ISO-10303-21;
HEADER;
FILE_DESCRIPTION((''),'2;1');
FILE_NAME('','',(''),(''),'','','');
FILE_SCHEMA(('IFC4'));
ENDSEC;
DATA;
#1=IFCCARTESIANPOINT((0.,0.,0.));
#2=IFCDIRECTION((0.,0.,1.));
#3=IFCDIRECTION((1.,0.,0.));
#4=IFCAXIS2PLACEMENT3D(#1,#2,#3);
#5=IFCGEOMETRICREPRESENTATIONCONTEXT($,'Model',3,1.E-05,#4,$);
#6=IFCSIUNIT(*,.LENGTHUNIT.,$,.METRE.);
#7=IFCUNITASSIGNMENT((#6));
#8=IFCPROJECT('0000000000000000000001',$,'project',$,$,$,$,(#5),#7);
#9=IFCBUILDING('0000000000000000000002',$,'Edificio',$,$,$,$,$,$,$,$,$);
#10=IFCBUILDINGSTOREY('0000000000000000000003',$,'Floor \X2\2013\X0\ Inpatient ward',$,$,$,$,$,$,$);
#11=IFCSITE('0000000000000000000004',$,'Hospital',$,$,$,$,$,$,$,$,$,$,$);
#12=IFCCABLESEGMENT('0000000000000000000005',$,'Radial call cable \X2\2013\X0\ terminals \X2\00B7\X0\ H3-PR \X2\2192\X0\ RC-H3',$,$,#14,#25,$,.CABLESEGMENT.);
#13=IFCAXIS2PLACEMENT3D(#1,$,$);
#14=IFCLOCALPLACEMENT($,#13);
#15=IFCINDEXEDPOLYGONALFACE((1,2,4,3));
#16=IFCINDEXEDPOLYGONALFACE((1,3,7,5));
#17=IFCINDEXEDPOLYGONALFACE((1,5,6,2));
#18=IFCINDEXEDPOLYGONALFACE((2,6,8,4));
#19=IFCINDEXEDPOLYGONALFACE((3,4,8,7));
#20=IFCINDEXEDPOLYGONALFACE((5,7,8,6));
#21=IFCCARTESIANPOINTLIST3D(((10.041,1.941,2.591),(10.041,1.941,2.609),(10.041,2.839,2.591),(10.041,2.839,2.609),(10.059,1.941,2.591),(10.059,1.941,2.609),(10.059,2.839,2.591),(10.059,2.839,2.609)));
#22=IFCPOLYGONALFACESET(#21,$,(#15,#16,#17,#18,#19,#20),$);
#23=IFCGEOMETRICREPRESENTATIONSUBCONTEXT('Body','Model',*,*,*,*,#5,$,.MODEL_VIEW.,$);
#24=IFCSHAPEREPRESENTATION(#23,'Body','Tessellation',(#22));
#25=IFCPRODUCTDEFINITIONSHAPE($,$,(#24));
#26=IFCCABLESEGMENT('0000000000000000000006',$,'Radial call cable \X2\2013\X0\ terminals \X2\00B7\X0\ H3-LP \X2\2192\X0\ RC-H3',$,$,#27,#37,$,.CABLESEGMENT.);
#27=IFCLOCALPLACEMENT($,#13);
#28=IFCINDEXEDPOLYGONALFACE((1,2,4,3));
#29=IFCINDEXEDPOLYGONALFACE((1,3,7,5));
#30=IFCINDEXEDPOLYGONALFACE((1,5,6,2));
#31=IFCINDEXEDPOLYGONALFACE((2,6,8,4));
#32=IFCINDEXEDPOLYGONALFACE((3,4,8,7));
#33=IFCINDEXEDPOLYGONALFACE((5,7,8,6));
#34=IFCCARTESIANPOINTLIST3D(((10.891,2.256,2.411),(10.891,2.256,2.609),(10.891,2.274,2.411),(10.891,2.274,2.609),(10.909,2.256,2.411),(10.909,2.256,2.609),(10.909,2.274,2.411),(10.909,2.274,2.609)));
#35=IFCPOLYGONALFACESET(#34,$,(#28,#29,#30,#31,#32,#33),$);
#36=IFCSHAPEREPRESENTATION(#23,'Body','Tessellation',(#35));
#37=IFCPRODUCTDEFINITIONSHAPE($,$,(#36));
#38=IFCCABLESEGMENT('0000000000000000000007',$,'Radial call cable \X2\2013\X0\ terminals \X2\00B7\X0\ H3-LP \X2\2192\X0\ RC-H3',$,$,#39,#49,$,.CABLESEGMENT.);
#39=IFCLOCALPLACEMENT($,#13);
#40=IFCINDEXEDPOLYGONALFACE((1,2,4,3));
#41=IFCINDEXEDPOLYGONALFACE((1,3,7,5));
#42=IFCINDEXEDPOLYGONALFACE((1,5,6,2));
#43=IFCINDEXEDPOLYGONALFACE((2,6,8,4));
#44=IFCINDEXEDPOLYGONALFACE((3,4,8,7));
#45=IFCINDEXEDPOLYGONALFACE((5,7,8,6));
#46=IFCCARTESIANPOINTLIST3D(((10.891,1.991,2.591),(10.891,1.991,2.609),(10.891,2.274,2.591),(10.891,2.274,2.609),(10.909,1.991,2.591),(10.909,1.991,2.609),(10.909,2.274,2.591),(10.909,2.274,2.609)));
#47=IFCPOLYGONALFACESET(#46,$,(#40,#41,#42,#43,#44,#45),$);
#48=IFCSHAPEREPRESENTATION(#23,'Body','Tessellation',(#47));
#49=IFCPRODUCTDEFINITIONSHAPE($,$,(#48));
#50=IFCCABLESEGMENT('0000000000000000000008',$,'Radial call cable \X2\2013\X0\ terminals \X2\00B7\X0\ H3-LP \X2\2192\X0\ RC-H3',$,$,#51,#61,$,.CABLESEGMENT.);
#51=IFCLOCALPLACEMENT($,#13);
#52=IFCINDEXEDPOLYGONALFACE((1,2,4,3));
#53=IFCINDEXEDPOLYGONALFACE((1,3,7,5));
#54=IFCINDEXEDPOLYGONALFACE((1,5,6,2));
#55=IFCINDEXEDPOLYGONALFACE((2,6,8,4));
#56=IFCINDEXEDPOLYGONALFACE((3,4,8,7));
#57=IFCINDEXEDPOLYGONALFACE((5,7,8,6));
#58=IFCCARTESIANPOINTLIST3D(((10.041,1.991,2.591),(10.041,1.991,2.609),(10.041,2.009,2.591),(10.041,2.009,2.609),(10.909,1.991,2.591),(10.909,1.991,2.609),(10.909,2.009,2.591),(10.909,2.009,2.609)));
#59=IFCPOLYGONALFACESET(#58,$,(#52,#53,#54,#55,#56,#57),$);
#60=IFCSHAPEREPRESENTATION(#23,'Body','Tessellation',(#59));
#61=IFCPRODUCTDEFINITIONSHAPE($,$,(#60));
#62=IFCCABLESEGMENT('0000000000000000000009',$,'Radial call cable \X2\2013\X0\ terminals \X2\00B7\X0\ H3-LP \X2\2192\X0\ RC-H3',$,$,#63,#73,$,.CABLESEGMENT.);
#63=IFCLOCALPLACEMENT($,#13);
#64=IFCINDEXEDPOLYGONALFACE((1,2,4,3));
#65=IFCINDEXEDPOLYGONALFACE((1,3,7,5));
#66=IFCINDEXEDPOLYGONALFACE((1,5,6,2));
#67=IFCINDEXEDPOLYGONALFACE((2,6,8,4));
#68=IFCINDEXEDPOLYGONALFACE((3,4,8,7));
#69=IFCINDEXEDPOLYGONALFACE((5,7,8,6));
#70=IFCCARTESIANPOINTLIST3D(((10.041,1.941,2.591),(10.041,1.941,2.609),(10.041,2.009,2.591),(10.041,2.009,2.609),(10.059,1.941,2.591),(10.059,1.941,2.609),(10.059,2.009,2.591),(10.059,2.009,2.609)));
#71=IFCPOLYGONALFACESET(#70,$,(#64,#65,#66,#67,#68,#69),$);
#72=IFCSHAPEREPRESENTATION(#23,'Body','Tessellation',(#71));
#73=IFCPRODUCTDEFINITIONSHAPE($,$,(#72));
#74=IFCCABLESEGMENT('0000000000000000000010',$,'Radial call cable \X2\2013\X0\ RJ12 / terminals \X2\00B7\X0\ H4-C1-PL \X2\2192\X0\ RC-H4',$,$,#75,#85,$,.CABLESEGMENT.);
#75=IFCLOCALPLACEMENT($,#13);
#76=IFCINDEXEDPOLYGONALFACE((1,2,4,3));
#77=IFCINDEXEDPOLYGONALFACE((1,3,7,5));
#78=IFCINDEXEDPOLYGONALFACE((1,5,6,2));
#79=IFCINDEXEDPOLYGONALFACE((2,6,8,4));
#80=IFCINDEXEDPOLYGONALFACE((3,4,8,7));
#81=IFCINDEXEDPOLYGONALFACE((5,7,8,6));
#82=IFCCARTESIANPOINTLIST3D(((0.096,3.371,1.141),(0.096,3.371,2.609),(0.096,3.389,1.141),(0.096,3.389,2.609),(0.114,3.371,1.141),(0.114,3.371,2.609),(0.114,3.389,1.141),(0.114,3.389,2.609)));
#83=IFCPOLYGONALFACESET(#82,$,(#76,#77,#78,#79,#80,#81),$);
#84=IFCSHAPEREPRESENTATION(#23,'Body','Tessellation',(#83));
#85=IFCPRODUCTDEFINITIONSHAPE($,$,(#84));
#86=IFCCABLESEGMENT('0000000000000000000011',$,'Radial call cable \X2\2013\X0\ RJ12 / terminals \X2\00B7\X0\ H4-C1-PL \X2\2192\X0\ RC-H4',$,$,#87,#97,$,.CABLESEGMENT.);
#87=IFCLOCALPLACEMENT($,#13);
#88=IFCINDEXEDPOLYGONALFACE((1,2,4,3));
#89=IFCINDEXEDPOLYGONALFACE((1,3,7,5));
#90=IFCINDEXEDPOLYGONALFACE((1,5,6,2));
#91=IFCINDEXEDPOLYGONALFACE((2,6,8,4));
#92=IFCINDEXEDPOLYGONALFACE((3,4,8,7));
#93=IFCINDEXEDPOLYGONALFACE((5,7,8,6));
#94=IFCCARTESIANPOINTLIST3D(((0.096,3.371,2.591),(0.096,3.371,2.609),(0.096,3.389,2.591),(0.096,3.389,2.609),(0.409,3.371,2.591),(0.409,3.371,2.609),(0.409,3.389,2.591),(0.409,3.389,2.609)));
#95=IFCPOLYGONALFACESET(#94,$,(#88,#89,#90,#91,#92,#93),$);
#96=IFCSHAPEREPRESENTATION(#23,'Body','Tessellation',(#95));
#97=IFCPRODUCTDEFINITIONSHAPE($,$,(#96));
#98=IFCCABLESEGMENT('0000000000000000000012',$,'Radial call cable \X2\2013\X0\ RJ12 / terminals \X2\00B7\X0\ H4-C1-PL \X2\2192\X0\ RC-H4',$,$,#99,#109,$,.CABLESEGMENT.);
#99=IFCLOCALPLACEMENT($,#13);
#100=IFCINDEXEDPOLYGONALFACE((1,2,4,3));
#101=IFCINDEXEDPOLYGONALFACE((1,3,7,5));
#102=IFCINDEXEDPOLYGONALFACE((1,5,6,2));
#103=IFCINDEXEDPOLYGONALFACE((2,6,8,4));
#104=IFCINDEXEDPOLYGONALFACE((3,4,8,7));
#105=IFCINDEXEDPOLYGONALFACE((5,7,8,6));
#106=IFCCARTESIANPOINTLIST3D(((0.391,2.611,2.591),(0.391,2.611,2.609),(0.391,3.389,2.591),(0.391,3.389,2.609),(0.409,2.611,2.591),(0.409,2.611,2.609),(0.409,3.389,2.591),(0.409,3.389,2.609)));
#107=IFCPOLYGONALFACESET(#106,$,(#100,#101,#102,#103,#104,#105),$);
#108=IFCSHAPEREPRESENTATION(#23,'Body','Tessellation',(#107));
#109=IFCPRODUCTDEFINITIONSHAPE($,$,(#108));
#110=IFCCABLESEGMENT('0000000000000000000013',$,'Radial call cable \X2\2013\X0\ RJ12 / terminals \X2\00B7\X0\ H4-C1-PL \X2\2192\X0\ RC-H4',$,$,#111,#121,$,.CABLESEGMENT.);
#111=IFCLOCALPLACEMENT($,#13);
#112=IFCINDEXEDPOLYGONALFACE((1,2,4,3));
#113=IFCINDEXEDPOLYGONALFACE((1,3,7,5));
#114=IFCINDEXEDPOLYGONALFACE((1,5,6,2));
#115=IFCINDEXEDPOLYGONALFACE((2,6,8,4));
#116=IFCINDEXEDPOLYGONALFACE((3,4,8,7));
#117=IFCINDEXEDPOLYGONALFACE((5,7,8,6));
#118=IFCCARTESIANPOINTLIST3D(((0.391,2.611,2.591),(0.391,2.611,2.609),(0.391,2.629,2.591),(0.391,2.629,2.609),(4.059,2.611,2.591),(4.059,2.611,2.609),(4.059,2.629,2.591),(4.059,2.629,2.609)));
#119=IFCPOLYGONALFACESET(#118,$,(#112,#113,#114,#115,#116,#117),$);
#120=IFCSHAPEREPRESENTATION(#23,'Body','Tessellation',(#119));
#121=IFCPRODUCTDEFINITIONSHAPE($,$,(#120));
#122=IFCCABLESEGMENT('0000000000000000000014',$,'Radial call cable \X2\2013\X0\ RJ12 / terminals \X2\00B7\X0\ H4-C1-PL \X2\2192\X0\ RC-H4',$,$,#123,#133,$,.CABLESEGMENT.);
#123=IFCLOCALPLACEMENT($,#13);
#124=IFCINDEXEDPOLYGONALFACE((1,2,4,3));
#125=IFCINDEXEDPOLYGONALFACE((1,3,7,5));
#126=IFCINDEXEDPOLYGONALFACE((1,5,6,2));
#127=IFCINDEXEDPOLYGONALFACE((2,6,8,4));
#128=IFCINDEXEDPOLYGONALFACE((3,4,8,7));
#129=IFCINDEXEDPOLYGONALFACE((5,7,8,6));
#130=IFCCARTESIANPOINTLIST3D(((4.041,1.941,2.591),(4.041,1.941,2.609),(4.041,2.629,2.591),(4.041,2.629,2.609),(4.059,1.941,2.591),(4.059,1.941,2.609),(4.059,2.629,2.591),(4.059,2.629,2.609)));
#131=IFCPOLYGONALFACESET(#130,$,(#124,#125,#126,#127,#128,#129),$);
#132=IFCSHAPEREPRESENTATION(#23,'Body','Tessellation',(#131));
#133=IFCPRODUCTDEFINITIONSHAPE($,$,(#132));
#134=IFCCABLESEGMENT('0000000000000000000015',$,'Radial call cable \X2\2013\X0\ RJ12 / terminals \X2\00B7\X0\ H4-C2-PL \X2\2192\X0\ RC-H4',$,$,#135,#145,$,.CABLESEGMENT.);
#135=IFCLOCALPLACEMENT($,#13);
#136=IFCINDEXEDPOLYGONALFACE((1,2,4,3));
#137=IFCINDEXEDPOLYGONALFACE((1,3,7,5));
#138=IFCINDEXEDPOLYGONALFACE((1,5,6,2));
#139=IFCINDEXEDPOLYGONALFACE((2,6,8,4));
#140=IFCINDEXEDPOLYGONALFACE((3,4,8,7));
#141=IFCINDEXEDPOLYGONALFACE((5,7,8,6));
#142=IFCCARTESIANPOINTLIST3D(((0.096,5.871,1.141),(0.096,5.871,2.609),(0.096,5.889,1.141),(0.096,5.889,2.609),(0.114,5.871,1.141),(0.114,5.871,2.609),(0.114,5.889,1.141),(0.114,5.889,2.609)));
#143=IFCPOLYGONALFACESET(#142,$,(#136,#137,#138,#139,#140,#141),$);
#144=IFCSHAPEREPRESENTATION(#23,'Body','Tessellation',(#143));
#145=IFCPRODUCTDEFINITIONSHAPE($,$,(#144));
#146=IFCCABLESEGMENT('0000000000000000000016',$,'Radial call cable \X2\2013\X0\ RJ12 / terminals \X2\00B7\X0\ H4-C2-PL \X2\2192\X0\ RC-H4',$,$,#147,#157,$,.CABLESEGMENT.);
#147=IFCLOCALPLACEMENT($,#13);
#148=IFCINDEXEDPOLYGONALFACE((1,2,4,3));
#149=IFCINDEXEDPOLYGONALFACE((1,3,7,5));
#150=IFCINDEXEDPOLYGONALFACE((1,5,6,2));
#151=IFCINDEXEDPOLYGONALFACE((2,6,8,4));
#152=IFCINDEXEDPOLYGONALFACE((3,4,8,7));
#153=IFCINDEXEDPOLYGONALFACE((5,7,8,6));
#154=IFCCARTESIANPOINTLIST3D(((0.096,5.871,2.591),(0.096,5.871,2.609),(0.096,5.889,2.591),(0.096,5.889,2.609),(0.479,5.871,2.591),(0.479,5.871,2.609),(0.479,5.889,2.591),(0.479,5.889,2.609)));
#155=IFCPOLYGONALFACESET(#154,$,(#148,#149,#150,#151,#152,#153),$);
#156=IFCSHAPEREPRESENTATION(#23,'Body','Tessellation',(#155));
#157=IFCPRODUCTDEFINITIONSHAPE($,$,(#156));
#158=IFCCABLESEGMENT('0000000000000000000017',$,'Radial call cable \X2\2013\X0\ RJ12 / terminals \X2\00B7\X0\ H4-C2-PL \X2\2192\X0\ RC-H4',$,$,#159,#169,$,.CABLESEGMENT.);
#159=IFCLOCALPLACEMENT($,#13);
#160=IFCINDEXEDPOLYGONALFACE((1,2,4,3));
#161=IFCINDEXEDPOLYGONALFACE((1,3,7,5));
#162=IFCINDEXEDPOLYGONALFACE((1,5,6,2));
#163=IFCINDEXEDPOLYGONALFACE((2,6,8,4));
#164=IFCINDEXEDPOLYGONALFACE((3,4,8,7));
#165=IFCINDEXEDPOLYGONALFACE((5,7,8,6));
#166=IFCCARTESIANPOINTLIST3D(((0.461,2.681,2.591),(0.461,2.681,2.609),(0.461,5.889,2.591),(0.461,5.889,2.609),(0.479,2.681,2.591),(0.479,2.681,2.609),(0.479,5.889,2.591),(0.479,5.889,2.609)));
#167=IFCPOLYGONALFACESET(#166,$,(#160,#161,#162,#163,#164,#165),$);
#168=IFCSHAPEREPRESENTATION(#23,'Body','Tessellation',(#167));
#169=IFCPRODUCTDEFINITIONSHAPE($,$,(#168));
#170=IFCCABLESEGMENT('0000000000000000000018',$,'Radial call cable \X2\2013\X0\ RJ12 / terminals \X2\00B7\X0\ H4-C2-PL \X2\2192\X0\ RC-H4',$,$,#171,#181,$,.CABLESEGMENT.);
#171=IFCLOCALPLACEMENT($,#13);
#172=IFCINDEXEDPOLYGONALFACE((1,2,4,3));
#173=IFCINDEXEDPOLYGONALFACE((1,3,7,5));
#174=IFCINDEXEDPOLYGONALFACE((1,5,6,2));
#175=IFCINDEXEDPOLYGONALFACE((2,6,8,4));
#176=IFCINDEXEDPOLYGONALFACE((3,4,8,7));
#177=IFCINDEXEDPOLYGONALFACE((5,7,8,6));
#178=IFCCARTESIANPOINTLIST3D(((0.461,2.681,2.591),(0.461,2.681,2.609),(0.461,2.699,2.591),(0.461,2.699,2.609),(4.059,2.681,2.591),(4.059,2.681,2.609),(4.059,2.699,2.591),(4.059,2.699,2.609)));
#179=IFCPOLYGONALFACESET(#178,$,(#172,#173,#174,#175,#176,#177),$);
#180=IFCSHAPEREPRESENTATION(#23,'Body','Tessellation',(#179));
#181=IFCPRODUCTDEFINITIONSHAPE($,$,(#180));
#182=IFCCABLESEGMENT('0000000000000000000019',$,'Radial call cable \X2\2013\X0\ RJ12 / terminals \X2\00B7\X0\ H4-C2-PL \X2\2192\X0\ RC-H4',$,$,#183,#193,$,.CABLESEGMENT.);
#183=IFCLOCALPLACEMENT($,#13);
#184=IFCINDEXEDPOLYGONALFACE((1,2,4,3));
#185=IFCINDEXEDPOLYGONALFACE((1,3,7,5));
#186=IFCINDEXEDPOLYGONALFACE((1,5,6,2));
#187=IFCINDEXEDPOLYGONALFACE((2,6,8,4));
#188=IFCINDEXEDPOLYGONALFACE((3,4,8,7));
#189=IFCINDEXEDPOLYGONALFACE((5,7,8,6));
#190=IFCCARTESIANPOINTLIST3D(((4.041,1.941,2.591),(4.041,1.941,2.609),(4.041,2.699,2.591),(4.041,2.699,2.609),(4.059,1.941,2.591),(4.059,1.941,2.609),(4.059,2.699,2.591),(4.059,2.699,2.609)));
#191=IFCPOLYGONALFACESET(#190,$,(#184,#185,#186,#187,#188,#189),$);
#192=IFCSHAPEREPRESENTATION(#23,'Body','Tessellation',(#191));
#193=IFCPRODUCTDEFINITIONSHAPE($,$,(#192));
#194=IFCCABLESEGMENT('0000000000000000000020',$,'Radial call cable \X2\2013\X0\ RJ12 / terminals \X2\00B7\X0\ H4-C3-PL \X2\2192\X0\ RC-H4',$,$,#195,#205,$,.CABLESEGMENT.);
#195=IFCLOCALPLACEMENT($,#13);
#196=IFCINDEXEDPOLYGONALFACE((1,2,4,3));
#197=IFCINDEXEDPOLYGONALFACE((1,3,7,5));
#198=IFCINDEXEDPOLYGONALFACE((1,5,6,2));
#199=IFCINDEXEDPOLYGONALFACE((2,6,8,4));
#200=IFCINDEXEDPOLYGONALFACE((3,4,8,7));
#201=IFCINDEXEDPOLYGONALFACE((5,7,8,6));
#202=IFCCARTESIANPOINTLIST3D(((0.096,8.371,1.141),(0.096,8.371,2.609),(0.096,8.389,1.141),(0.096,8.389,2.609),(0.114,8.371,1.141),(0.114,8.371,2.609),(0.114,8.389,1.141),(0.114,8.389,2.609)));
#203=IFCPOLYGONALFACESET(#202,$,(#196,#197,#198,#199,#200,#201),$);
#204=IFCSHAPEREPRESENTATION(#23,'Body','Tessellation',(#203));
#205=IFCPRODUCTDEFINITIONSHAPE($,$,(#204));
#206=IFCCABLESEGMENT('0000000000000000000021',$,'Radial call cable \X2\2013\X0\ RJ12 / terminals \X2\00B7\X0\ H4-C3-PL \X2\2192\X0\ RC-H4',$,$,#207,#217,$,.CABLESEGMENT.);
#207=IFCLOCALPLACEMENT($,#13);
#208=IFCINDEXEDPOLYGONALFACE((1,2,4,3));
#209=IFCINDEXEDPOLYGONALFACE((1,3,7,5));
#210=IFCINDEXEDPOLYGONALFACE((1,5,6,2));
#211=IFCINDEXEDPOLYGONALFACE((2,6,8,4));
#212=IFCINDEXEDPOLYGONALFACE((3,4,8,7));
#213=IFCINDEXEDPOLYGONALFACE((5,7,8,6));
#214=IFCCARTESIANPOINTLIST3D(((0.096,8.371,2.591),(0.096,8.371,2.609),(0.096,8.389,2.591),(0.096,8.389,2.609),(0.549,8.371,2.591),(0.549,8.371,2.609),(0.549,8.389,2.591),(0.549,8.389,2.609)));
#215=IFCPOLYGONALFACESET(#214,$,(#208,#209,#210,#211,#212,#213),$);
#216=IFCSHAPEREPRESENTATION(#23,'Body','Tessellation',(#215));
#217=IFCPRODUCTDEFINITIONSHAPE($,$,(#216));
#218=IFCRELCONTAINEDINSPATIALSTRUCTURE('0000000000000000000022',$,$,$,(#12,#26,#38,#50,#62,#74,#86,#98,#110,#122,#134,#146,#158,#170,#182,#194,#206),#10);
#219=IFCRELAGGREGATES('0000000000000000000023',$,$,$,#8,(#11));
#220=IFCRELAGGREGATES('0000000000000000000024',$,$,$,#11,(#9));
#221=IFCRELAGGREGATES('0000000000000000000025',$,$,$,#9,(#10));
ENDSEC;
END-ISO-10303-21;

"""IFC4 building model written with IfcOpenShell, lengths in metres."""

from ifc_helpers import new_model, si_unit, frame, origin_with_axes, context, subcontext, project, spatial, line, indexed_curve, outline, extrude, element, save


model = new_model("IFC4")

# Units and contexts
model_context = context("Model", 3, precision=1e-05, world=origin_with_axes())
body_context = subcontext(model_context, "Body", "Model", "MODEL_VIEW")
ifc_project = project(units=[si_unit("LENGTHUNIT", "METRE")], contexts=[model_context])

# Site, building, storey
site = spatial("IfcSite", under=ifc_project, Name="Hospital")
building = spatial("IfcBuilding", under=site, Name="Edificio")
storey = spatial("IfcBuildingStorey", under=building, Name="Floor – Inpatient ward")

# Cable segments
element("IfcCableSegment", 1, inside=storey, Name="Radial call cable – terminals · H3-PR → RC-H3", PredefinedType="CABLESEGMENT", context=body_context, shape_type="SweptSolid", body=[
    extrude(outline(indexed_curve([(0.0, 0.0), (0.018, 0.0), (0.018, 0.898), (0.0, 0.898)], segments=[line(1, 2, 3, 4, 1)])), frame((10.041, 1.941, 2.591), z_axis=(0.0, 0.0, 1.0), x_axis=(1.0, 0.0, 0.0)), (0.0, 0.0, 1.0), 0.018),
])
element("IfcCableSegment", 2, inside=storey, Name="Radial call cable – terminals · H3-LP → RC-H3", PredefinedType="CABLESEGMENT", context=body_context, shape_type="SweptSolid", body=[
    extrude(outline(indexed_curve([(0.0, 0.0), (0.018, 0.0), (0.018, 0.018), (0.0, 0.018)], segments=[line(1, 2, 3, 4, 1)])), frame((10.891, 2.256, 2.411), z_axis=(0.0, 0.0, 1.0), x_axis=(1.0, 0.0, 0.0)), (0.0, 0.0, 1.0), 0.198),
])
element("IfcCableSegment", 3, inside=storey, Name="Radial call cable – terminals · H3-LP → RC-H3", PredefinedType="CABLESEGMENT", context=body_context, shape_type="SweptSolid", body=[
    extrude(outline(indexed_curve([(0.0, 0.0), (0.018, 0.0), (0.018, 0.283), (0.0, 0.283)], segments=[line(1, 2, 3, 4, 1)])), frame((10.891, 1.991, 2.591), z_axis=(0.0, 0.0, 1.0), x_axis=(1.0, 0.0, 0.0)), (0.0, 0.0, 1.0), 0.018),
])
element("IfcCableSegment", 4, inside=storey, Name="Radial call cable – terminals · H3-LP → RC-H3", PredefinedType="CABLESEGMENT", context=body_context, shape_type="SweptSolid", body=[
    extrude(outline(indexed_curve([(0.0, 0.0), (0.868, 0.0), (0.868, 0.018), (0.0, 0.018)], segments=[line(1, 2, 3, 4, 1)])), frame((10.041, 1.991, 2.591), z_axis=(0.0, 0.0, 1.0), x_axis=(1.0, 0.0, 0.0)), (0.0, 0.0, 1.0), 0.018),
])
element("IfcCableSegment", 5, inside=storey, Name="Radial call cable – terminals · H3-LP → RC-H3", PredefinedType="CABLESEGMENT", context=body_context, shape_type="SweptSolid", body=[
    extrude(outline(indexed_curve([(0.0, 0.0), (0.018, 0.0), (0.018, 0.068), (0.0, 0.068)], segments=[line(1, 2, 3, 4, 1)])), frame((10.041, 1.941, 2.591), z_axis=(0.0, 0.0, 1.0), x_axis=(1.0, 0.0, 0.0)), (0.0, 0.0, 1.0), 0.018),
])
element("IfcCableSegment", 6, inside=storey, Name="Radial call cable – RJ12 / terminals · H4-C1-PL → RC-H4", PredefinedType="CABLESEGMENT", context=body_context, shape_type="SweptSolid", body=[
    extrude(outline(indexed_curve([(0.0, 0.0), (0.018, 0.0), (0.018, 0.018), (0.0, 0.018)], segments=[line(1, 2, 3, 4, 1)])), frame((0.096, 3.371, 1.141), z_axis=(0.0, 0.0, 1.0), x_axis=(1.0, 0.0, 0.0)), (0.0, 0.0, 1.0), 1.468),
])
element("IfcCableSegment", 7, inside=storey, Name="Radial call cable – RJ12 / terminals · H4-C1-PL → RC-H4", PredefinedType="CABLESEGMENT", context=body_context, shape_type="SweptSolid", body=[
    extrude(outline(indexed_curve([(0.0, 0.0), (0.313, 0.0), (0.313, 0.018), (0.0, 0.018)], segments=[line(1, 2, 3, 4, 1)])), frame((0.096, 3.371, 2.591), z_axis=(0.0, 0.0, 1.0), x_axis=(1.0, 0.0, 0.0)), (0.0, 0.0, 1.0), 0.018),
])
element("IfcCableSegment", 8, inside=storey, Name="Radial call cable – RJ12 / terminals · H4-C1-PL → RC-H4", PredefinedType="CABLESEGMENT", context=body_context, shape_type="SweptSolid", body=[
    extrude(outline(indexed_curve([(0.0, 0.0), (0.018, 0.0), (0.018, 0.778), (0.0, 0.778)], segments=[line(1, 2, 3, 4, 1)])), frame((0.391, 2.611, 2.591), z_axis=(0.0, 0.0, 1.0), x_axis=(1.0, 0.0, 0.0)), (0.0, 0.0, 1.0), 0.018),
])
element("IfcCableSegment", 9, inside=storey, Name="Radial call cable – RJ12 / terminals · H4-C1-PL → RC-H4", PredefinedType="CABLESEGMENT", context=body_context, shape_type="SweptSolid", body=[
    extrude(outline(indexed_curve([(0.0, 0.0), (3.668, 0.0), (3.668, 0.018), (0.0, 0.018)], segments=[line(1, 2, 3, 4, 1)])), frame((0.391, 2.611, 2.591), z_axis=(0.0, 0.0, 1.0), x_axis=(1.0, 0.0, 0.0)), (0.0, 0.0, 1.0), 0.018),
])
element("IfcCableSegment", 10, inside=storey, Name="Radial call cable – RJ12 / terminals · H4-C1-PL → RC-H4", PredefinedType="CABLESEGMENT", context=body_context, shape_type="SweptSolid", body=[
    extrude(outline(indexed_curve([(0.0, 0.0), (0.018, 0.0), (0.018, 0.688), (0.0, 0.688)], segments=[line(1, 2, 3, 4, 1)])), frame((4.041, 1.941, 2.591), z_axis=(0.0, 0.0, 1.0), x_axis=(1.0, 0.0, 0.0)), (0.0, 0.0, 1.0), 0.018),
])
element("IfcCableSegment", 11, inside=storey, Name="Radial call cable – RJ12 / terminals · H4-C2-PL → RC-H4", PredefinedType="CABLESEGMENT", context=body_context, shape_type="SweptSolid", body=[
    extrude(outline(indexed_curve([(0.0, 0.0), (0.018, 0.0), (0.018, 0.018), (0.0, 0.018)], segments=[line(1, 2, 3, 4, 1)])), frame((0.096, 5.871, 1.141), z_axis=(0.0, 0.0, 1.0), x_axis=(1.0, 0.0, 0.0)), (0.0, 0.0, 1.0), 1.468),
])
element("IfcCableSegment", 12, inside=storey, Name="Radial call cable – RJ12 / terminals · H4-C2-PL → RC-H4", PredefinedType="CABLESEGMENT", context=body_context, shape_type="SweptSolid", body=[
    extrude(outline(indexed_curve([(0.0, 0.0), (0.383, 0.0), (0.383, 0.018), (0.0, 0.018)], segments=[line(1, 2, 3, 4, 1)])), frame((0.096, 5.871, 2.591), z_axis=(0.0, 0.0, 1.0), x_axis=(1.0, 0.0, 0.0)), (0.0, 0.0, 1.0), 0.018),
])
element("IfcCableSegment", 13, inside=storey, Name="Radial call cable – RJ12 / terminals · H4-C2-PL → RC-H4", PredefinedType="CABLESEGMENT", context=body_context, shape_type="SweptSolid", body=[
    extrude(outline(indexed_curve([(0.0, 0.0), (0.018, 0.0), (0.018, 3.208), (0.0, 3.208)], segments=[line(1, 2, 3, 4, 1)])), frame((0.461, 2.681, 2.591), z_axis=(0.0, 0.0, 1.0), x_axis=(1.0, 0.0, 0.0)), (0.0, 0.0, 1.0), 0.018),
])
element("IfcCableSegment", 14, inside=storey, Name="Radial call cable – RJ12 / terminals · H4-C2-PL → RC-H4", PredefinedType="CABLESEGMENT", context=body_context, shape_type="SweptSolid", body=[
    extrude(outline(indexed_curve([(0.0, 0.0), (3.598, 0.0), (3.598, 0.018), (0.0, 0.018)], segments=[line(1, 2, 3, 4, 1)])), frame((0.461, 2.681, 2.591), z_axis=(0.0, 0.0, 1.0), x_axis=(1.0, 0.0, 0.0)), (0.0, 0.0, 1.0), 0.018),
])
element("IfcCableSegment", 15, inside=storey, Name="Radial call cable – RJ12 / terminals · H4-C2-PL → RC-H4", PredefinedType="CABLESEGMENT", context=body_context, shape_type="SweptSolid", body=[
    extrude(outline(indexed_curve([(0.0, 0.0), (0.018, 0.0), (0.018, 0.758), (0.0, 0.758)], segments=[line(1, 2, 3, 4, 1)])), frame((4.041, 1.941, 2.591), z_axis=(0.0, 0.0, 1.0), x_axis=(1.0, 0.0, 0.0)), (0.0, 0.0, 1.0), 0.018),
])
element("IfcCableSegment", 16, inside=storey, Name="Radial call cable – RJ12 / terminals · H4-C3-PL → RC-H4", PredefinedType="CABLESEGMENT", context=body_context, shape_type="SweptSolid", body=[
    extrude(outline(indexed_curve([(0.0, 0.0), (0.018, 0.0), (0.018, 0.018), (0.0, 0.018)], segments=[line(1, 2, 3, 4, 1)])), frame((0.096, 8.371, 1.141), z_axis=(0.0, 0.0, 1.0), x_axis=(1.0, 0.0, 0.0)), (0.0, 0.0, 1.0), 1.468),
])
element("IfcCableSegment", 17, inside=storey, Name="Radial call cable – RJ12 / terminals · H4-C3-PL → RC-H4", PredefinedType="CABLESEGMENT", context=body_context, shape_type="SweptSolid", body=[
    extrude(outline(indexed_curve([(0.0, 0.0), (0.453, 0.0), (0.453, 0.018), (0.0, 0.018)], segments=[line(1, 2, 3, 4, 1)])), frame((0.096, 8.371, 2.591), z_axis=(0.0, 0.0, 1.0), x_axis=(1.0, 0.0, 0.0)), (0.0, 0.0, 1.0), 0.018),
])

save(model, "model.ifc")
